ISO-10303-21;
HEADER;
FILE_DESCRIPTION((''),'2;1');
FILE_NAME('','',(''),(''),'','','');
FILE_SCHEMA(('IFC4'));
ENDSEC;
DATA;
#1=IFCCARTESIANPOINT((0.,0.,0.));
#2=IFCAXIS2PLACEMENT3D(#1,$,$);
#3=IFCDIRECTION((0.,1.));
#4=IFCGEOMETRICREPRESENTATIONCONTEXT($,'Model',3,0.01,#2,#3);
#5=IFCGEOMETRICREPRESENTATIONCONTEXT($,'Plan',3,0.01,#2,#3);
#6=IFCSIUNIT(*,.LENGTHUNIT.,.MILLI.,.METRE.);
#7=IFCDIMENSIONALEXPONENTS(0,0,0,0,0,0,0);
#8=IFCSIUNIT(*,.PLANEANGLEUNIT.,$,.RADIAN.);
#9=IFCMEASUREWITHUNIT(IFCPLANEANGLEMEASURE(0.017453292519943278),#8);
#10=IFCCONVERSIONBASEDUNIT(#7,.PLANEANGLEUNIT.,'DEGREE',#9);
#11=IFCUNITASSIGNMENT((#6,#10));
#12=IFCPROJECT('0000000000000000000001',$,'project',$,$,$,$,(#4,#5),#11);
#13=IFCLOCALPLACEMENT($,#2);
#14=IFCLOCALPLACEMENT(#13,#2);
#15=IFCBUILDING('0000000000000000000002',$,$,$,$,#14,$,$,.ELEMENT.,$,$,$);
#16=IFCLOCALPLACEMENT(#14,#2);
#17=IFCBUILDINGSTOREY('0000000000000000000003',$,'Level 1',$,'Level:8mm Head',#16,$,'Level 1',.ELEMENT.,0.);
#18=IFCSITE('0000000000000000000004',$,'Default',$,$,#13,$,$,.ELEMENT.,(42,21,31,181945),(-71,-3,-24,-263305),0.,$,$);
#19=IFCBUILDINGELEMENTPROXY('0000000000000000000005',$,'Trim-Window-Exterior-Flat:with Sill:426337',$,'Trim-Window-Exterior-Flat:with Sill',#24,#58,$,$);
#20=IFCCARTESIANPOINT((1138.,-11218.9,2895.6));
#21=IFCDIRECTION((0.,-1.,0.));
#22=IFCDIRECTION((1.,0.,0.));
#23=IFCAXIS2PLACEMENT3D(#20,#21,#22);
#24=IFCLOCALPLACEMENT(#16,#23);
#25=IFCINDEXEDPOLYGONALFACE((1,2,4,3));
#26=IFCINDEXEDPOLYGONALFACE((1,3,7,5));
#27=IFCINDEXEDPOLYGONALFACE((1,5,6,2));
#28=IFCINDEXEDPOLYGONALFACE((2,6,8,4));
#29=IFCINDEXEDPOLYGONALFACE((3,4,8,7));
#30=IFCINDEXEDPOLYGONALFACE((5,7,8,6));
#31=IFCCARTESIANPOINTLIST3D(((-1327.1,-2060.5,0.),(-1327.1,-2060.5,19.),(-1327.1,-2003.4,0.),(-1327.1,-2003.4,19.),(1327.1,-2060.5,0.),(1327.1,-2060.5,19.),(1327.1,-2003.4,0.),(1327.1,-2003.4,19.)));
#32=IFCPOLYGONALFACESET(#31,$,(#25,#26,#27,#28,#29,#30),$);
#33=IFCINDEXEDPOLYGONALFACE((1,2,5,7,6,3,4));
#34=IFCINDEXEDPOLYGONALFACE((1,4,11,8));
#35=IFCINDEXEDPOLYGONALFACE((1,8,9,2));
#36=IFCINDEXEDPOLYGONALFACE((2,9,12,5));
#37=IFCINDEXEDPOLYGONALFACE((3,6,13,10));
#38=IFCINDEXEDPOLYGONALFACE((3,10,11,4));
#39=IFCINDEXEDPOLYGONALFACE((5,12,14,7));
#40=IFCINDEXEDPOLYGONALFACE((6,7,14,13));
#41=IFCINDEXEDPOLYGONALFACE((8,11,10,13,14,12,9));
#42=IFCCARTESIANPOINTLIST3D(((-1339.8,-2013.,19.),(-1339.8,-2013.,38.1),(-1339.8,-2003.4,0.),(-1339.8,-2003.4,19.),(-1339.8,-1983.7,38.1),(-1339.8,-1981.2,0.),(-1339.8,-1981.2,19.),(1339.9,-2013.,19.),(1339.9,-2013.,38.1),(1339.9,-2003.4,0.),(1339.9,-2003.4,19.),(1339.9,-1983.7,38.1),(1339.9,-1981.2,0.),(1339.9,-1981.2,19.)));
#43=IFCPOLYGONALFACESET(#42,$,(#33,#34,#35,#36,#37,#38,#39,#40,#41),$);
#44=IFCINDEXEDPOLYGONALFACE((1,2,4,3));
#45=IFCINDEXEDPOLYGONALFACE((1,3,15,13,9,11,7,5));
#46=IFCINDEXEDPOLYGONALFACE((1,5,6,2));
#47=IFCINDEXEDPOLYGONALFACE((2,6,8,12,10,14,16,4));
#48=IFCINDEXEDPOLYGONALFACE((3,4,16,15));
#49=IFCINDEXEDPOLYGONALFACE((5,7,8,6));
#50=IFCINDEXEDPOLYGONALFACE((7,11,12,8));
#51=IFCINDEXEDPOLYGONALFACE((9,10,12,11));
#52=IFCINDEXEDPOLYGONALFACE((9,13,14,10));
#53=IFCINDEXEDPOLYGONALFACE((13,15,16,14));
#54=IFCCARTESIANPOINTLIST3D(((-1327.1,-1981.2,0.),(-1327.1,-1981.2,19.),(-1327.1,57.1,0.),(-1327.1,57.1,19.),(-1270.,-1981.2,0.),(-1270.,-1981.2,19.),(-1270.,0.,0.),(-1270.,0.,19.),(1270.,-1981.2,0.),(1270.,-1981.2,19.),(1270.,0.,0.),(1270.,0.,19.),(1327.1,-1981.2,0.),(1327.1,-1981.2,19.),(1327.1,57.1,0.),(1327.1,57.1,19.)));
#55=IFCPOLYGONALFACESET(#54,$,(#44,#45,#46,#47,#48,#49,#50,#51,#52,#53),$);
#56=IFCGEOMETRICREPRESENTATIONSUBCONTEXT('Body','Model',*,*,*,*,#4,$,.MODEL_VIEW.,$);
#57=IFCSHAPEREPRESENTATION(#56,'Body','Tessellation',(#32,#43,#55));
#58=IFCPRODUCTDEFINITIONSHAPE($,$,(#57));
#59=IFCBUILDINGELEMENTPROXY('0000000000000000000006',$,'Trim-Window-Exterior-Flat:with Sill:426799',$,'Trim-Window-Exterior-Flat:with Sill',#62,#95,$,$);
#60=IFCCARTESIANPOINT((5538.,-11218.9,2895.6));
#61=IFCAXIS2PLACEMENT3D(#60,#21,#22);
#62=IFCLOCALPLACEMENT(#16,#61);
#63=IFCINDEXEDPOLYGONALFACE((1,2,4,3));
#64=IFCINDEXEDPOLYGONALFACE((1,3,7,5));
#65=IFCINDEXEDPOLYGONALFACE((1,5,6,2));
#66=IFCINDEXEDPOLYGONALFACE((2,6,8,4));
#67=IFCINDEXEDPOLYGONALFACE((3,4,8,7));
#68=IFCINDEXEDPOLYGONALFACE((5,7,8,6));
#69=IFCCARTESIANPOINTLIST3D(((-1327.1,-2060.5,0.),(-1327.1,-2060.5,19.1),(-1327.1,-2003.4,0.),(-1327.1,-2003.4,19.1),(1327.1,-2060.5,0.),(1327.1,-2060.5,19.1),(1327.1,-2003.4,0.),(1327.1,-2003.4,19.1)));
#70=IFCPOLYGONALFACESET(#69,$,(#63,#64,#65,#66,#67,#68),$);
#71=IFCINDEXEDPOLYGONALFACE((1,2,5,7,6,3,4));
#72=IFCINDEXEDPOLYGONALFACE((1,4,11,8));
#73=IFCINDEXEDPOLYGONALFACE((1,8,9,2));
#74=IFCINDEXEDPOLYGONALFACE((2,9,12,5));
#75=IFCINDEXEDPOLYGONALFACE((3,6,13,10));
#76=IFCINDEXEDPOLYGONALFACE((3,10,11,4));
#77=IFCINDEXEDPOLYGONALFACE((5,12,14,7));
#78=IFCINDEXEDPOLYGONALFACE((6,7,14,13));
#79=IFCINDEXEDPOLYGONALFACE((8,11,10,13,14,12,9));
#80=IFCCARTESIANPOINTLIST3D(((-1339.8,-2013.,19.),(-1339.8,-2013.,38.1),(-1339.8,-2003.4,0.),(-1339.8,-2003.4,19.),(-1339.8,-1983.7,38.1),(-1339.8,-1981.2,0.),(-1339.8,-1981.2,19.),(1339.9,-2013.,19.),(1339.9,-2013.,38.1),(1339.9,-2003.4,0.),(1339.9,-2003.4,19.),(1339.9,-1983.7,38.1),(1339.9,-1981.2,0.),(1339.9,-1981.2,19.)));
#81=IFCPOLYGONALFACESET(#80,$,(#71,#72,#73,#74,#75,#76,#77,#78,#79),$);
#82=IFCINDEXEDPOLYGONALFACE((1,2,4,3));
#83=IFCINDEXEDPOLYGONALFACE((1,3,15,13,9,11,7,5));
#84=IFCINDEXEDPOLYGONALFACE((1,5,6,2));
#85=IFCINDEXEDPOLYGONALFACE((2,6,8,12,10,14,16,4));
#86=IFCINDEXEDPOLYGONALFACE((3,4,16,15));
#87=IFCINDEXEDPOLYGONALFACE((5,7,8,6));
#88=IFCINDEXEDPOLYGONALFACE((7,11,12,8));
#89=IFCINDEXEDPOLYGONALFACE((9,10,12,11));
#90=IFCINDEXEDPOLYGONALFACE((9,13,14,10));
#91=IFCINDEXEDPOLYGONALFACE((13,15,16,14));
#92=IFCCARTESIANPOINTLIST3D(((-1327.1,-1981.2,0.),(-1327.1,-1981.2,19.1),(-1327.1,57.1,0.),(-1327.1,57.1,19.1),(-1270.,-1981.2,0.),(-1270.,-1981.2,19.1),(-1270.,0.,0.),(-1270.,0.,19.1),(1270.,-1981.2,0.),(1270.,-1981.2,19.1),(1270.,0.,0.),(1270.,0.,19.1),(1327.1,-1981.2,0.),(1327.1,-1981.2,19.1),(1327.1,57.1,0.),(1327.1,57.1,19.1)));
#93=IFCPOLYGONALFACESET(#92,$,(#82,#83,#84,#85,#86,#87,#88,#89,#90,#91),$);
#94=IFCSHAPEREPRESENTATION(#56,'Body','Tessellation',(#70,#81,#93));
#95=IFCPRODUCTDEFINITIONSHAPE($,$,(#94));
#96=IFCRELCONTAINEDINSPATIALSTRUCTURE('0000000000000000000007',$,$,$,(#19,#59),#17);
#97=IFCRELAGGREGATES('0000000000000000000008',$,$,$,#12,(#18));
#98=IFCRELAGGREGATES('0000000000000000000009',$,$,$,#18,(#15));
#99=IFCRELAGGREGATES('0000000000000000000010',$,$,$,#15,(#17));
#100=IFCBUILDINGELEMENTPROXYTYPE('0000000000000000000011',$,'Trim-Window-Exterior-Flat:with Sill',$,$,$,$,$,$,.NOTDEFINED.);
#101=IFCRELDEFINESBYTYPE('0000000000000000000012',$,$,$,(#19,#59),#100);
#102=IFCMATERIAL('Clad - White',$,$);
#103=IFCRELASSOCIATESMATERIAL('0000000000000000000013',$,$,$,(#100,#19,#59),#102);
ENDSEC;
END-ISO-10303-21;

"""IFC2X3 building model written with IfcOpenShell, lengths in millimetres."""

from ifc_helpers import new_model, entity, si_unit, converted_unit, direction, frame, frame_2d, origin, place, context, subcontext, project, spatial, polyline, rectangle, outline, extrude, source, transform, mapped, material, type_object, type_shapes, element, save


model = new_model("IFC2X3")

# Units and contexts
model_context = context("Model", 3, precision=0.01, world=origin(), true_north=direction((0.0, 1.0)))
plan_context = context("Plan", 3, precision=0.01, world=origin(), true_north=direction((0.0, 1.0)))
body_context = subcontext(model_context, "Body", "Model", "MODEL_VIEW")
ifc_project = project(units=[si_unit("LENGTHUNIT", "METRE", prefix="MILLI"), converted_unit("PLANEANGLEUNIT", "DEGREE", entity("IfcPlaneAngleMeasure", 0.017453292519943278), si_unit("PLANEANGLEUNIT", "RADIAN"), dimensions=[0, 0, 0, 0, 0, 0, 0])], contexts=[model_context, plan_context])

# Site, building, storey
site_placement = place(None, origin())
site = spatial("IfcSite", under=ifc_project, at=site_placement, Name="Default", CompositionType="ELEMENT", RefLatitude=(42, 21, 31, 181945), RefLongitude=(-71, -3, -24, -263305), RefElevation=0.0)
building_placement = place(site_placement, origin())
building = spatial("IfcBuilding", under=site, at=building_placement, CompositionType="ELEMENT")
storey_placement = place(building_placement, origin())
storey = spatial("IfcBuildingStorey", under=building, at=storey_placement, Name="Level 1", ObjectType="Level:8mm Head", LongName="Level 1", CompositionType="ELEMENT", Elevation=0.0)

# Building element proxies
ifc_material_1 = material(Name="Clad - White")
building_element_proxy_type_1 = type_object("IfcBuildingElementProxyType", Name="Trim-Window-Exterior-Flat:with Sill", PredefinedType="NOTDEFINED", material=ifc_material_1)
shared_shape_1 = source(origin(), body_context, "Body", "SweptSolid", [
    extrude(rectangle(XDim=2654.3, YDim=57.2, at=frame_2d((0.0, 0.0), x_axis=(1.0, 0.0))), frame((0.0, -2032.0, 0.0), z_axis=(0.0, 0.0, 1.0), x_axis=(-1.0, 0.0, 0.0)), (0.0, 0.0, 1.0), 19.0),
    extrude(outline(polyline([(-19.0, -16.0), (0.0, -16.0), (0.0, -6.4), (19.0, -6.4), (19.0, 15.8), (0.0, 15.8), (-19.0, 13.3), (-19.0, -16.0)])), frame((-1339.8, -1997.0, 19.0), z_axis=(1.0, 0.0, 0.0), x_axis=(0.0, 0.0, -1.0)), (0.0, 0.0, 1.0), 2679.7),
    extrude(outline(polyline([(-1033.5, -1327.1), (1004.9, -1327.1), (1004.9, -1270.0), (-976.3, -1270.0), (-976.3, 1270.0), (1004.9, 1270.0), (1004.9, 1327.1), (-1033.5, 1327.1), (-1033.5, -1327.1)])), frame((0.0, -976.3, 0.0), z_axis=(0.0, 0.0, 1.0), x_axis=(0.0, -1.0, 0.0)), (0.0, 0.0, 1.0), 19.0),
])
type_shapes(building_element_proxy_type_1, [shared_shape_1])
for number, where, z_axis, x_axis, name in (
    (1, (1138.0, -11218.9, 2895.6), (0.0, -1.0, 0.0), (1.0, 0.0, 0.0), "Trim-Window-Exterior-Flat:with Sill:426337"),
    (2, (5538.0, -11218.9, 2895.6), (0.0, -1.0, 0.0), (1.0, 0.0, 0.0), "Trim-Window-Exterior-Flat:with Sill:426799"),
):
    element("IfcBuildingElementProxy", number, at=place(storey_placement, frame(where, z_axis=z_axis, x_axis=x_axis)), inside=storey, type_object=building_element_proxy_type_1, material=ifc_material_1, Name=name, ObjectType="Trim-Window-Exterior-Flat:with Sill", context=body_context, shape_type="MappedRepresentation", body=[
        mapped(shared_shape_1, transform((0.0, 0.0, 0.0), scale=1.0)),
    ])

save(model, "model.ifc")
